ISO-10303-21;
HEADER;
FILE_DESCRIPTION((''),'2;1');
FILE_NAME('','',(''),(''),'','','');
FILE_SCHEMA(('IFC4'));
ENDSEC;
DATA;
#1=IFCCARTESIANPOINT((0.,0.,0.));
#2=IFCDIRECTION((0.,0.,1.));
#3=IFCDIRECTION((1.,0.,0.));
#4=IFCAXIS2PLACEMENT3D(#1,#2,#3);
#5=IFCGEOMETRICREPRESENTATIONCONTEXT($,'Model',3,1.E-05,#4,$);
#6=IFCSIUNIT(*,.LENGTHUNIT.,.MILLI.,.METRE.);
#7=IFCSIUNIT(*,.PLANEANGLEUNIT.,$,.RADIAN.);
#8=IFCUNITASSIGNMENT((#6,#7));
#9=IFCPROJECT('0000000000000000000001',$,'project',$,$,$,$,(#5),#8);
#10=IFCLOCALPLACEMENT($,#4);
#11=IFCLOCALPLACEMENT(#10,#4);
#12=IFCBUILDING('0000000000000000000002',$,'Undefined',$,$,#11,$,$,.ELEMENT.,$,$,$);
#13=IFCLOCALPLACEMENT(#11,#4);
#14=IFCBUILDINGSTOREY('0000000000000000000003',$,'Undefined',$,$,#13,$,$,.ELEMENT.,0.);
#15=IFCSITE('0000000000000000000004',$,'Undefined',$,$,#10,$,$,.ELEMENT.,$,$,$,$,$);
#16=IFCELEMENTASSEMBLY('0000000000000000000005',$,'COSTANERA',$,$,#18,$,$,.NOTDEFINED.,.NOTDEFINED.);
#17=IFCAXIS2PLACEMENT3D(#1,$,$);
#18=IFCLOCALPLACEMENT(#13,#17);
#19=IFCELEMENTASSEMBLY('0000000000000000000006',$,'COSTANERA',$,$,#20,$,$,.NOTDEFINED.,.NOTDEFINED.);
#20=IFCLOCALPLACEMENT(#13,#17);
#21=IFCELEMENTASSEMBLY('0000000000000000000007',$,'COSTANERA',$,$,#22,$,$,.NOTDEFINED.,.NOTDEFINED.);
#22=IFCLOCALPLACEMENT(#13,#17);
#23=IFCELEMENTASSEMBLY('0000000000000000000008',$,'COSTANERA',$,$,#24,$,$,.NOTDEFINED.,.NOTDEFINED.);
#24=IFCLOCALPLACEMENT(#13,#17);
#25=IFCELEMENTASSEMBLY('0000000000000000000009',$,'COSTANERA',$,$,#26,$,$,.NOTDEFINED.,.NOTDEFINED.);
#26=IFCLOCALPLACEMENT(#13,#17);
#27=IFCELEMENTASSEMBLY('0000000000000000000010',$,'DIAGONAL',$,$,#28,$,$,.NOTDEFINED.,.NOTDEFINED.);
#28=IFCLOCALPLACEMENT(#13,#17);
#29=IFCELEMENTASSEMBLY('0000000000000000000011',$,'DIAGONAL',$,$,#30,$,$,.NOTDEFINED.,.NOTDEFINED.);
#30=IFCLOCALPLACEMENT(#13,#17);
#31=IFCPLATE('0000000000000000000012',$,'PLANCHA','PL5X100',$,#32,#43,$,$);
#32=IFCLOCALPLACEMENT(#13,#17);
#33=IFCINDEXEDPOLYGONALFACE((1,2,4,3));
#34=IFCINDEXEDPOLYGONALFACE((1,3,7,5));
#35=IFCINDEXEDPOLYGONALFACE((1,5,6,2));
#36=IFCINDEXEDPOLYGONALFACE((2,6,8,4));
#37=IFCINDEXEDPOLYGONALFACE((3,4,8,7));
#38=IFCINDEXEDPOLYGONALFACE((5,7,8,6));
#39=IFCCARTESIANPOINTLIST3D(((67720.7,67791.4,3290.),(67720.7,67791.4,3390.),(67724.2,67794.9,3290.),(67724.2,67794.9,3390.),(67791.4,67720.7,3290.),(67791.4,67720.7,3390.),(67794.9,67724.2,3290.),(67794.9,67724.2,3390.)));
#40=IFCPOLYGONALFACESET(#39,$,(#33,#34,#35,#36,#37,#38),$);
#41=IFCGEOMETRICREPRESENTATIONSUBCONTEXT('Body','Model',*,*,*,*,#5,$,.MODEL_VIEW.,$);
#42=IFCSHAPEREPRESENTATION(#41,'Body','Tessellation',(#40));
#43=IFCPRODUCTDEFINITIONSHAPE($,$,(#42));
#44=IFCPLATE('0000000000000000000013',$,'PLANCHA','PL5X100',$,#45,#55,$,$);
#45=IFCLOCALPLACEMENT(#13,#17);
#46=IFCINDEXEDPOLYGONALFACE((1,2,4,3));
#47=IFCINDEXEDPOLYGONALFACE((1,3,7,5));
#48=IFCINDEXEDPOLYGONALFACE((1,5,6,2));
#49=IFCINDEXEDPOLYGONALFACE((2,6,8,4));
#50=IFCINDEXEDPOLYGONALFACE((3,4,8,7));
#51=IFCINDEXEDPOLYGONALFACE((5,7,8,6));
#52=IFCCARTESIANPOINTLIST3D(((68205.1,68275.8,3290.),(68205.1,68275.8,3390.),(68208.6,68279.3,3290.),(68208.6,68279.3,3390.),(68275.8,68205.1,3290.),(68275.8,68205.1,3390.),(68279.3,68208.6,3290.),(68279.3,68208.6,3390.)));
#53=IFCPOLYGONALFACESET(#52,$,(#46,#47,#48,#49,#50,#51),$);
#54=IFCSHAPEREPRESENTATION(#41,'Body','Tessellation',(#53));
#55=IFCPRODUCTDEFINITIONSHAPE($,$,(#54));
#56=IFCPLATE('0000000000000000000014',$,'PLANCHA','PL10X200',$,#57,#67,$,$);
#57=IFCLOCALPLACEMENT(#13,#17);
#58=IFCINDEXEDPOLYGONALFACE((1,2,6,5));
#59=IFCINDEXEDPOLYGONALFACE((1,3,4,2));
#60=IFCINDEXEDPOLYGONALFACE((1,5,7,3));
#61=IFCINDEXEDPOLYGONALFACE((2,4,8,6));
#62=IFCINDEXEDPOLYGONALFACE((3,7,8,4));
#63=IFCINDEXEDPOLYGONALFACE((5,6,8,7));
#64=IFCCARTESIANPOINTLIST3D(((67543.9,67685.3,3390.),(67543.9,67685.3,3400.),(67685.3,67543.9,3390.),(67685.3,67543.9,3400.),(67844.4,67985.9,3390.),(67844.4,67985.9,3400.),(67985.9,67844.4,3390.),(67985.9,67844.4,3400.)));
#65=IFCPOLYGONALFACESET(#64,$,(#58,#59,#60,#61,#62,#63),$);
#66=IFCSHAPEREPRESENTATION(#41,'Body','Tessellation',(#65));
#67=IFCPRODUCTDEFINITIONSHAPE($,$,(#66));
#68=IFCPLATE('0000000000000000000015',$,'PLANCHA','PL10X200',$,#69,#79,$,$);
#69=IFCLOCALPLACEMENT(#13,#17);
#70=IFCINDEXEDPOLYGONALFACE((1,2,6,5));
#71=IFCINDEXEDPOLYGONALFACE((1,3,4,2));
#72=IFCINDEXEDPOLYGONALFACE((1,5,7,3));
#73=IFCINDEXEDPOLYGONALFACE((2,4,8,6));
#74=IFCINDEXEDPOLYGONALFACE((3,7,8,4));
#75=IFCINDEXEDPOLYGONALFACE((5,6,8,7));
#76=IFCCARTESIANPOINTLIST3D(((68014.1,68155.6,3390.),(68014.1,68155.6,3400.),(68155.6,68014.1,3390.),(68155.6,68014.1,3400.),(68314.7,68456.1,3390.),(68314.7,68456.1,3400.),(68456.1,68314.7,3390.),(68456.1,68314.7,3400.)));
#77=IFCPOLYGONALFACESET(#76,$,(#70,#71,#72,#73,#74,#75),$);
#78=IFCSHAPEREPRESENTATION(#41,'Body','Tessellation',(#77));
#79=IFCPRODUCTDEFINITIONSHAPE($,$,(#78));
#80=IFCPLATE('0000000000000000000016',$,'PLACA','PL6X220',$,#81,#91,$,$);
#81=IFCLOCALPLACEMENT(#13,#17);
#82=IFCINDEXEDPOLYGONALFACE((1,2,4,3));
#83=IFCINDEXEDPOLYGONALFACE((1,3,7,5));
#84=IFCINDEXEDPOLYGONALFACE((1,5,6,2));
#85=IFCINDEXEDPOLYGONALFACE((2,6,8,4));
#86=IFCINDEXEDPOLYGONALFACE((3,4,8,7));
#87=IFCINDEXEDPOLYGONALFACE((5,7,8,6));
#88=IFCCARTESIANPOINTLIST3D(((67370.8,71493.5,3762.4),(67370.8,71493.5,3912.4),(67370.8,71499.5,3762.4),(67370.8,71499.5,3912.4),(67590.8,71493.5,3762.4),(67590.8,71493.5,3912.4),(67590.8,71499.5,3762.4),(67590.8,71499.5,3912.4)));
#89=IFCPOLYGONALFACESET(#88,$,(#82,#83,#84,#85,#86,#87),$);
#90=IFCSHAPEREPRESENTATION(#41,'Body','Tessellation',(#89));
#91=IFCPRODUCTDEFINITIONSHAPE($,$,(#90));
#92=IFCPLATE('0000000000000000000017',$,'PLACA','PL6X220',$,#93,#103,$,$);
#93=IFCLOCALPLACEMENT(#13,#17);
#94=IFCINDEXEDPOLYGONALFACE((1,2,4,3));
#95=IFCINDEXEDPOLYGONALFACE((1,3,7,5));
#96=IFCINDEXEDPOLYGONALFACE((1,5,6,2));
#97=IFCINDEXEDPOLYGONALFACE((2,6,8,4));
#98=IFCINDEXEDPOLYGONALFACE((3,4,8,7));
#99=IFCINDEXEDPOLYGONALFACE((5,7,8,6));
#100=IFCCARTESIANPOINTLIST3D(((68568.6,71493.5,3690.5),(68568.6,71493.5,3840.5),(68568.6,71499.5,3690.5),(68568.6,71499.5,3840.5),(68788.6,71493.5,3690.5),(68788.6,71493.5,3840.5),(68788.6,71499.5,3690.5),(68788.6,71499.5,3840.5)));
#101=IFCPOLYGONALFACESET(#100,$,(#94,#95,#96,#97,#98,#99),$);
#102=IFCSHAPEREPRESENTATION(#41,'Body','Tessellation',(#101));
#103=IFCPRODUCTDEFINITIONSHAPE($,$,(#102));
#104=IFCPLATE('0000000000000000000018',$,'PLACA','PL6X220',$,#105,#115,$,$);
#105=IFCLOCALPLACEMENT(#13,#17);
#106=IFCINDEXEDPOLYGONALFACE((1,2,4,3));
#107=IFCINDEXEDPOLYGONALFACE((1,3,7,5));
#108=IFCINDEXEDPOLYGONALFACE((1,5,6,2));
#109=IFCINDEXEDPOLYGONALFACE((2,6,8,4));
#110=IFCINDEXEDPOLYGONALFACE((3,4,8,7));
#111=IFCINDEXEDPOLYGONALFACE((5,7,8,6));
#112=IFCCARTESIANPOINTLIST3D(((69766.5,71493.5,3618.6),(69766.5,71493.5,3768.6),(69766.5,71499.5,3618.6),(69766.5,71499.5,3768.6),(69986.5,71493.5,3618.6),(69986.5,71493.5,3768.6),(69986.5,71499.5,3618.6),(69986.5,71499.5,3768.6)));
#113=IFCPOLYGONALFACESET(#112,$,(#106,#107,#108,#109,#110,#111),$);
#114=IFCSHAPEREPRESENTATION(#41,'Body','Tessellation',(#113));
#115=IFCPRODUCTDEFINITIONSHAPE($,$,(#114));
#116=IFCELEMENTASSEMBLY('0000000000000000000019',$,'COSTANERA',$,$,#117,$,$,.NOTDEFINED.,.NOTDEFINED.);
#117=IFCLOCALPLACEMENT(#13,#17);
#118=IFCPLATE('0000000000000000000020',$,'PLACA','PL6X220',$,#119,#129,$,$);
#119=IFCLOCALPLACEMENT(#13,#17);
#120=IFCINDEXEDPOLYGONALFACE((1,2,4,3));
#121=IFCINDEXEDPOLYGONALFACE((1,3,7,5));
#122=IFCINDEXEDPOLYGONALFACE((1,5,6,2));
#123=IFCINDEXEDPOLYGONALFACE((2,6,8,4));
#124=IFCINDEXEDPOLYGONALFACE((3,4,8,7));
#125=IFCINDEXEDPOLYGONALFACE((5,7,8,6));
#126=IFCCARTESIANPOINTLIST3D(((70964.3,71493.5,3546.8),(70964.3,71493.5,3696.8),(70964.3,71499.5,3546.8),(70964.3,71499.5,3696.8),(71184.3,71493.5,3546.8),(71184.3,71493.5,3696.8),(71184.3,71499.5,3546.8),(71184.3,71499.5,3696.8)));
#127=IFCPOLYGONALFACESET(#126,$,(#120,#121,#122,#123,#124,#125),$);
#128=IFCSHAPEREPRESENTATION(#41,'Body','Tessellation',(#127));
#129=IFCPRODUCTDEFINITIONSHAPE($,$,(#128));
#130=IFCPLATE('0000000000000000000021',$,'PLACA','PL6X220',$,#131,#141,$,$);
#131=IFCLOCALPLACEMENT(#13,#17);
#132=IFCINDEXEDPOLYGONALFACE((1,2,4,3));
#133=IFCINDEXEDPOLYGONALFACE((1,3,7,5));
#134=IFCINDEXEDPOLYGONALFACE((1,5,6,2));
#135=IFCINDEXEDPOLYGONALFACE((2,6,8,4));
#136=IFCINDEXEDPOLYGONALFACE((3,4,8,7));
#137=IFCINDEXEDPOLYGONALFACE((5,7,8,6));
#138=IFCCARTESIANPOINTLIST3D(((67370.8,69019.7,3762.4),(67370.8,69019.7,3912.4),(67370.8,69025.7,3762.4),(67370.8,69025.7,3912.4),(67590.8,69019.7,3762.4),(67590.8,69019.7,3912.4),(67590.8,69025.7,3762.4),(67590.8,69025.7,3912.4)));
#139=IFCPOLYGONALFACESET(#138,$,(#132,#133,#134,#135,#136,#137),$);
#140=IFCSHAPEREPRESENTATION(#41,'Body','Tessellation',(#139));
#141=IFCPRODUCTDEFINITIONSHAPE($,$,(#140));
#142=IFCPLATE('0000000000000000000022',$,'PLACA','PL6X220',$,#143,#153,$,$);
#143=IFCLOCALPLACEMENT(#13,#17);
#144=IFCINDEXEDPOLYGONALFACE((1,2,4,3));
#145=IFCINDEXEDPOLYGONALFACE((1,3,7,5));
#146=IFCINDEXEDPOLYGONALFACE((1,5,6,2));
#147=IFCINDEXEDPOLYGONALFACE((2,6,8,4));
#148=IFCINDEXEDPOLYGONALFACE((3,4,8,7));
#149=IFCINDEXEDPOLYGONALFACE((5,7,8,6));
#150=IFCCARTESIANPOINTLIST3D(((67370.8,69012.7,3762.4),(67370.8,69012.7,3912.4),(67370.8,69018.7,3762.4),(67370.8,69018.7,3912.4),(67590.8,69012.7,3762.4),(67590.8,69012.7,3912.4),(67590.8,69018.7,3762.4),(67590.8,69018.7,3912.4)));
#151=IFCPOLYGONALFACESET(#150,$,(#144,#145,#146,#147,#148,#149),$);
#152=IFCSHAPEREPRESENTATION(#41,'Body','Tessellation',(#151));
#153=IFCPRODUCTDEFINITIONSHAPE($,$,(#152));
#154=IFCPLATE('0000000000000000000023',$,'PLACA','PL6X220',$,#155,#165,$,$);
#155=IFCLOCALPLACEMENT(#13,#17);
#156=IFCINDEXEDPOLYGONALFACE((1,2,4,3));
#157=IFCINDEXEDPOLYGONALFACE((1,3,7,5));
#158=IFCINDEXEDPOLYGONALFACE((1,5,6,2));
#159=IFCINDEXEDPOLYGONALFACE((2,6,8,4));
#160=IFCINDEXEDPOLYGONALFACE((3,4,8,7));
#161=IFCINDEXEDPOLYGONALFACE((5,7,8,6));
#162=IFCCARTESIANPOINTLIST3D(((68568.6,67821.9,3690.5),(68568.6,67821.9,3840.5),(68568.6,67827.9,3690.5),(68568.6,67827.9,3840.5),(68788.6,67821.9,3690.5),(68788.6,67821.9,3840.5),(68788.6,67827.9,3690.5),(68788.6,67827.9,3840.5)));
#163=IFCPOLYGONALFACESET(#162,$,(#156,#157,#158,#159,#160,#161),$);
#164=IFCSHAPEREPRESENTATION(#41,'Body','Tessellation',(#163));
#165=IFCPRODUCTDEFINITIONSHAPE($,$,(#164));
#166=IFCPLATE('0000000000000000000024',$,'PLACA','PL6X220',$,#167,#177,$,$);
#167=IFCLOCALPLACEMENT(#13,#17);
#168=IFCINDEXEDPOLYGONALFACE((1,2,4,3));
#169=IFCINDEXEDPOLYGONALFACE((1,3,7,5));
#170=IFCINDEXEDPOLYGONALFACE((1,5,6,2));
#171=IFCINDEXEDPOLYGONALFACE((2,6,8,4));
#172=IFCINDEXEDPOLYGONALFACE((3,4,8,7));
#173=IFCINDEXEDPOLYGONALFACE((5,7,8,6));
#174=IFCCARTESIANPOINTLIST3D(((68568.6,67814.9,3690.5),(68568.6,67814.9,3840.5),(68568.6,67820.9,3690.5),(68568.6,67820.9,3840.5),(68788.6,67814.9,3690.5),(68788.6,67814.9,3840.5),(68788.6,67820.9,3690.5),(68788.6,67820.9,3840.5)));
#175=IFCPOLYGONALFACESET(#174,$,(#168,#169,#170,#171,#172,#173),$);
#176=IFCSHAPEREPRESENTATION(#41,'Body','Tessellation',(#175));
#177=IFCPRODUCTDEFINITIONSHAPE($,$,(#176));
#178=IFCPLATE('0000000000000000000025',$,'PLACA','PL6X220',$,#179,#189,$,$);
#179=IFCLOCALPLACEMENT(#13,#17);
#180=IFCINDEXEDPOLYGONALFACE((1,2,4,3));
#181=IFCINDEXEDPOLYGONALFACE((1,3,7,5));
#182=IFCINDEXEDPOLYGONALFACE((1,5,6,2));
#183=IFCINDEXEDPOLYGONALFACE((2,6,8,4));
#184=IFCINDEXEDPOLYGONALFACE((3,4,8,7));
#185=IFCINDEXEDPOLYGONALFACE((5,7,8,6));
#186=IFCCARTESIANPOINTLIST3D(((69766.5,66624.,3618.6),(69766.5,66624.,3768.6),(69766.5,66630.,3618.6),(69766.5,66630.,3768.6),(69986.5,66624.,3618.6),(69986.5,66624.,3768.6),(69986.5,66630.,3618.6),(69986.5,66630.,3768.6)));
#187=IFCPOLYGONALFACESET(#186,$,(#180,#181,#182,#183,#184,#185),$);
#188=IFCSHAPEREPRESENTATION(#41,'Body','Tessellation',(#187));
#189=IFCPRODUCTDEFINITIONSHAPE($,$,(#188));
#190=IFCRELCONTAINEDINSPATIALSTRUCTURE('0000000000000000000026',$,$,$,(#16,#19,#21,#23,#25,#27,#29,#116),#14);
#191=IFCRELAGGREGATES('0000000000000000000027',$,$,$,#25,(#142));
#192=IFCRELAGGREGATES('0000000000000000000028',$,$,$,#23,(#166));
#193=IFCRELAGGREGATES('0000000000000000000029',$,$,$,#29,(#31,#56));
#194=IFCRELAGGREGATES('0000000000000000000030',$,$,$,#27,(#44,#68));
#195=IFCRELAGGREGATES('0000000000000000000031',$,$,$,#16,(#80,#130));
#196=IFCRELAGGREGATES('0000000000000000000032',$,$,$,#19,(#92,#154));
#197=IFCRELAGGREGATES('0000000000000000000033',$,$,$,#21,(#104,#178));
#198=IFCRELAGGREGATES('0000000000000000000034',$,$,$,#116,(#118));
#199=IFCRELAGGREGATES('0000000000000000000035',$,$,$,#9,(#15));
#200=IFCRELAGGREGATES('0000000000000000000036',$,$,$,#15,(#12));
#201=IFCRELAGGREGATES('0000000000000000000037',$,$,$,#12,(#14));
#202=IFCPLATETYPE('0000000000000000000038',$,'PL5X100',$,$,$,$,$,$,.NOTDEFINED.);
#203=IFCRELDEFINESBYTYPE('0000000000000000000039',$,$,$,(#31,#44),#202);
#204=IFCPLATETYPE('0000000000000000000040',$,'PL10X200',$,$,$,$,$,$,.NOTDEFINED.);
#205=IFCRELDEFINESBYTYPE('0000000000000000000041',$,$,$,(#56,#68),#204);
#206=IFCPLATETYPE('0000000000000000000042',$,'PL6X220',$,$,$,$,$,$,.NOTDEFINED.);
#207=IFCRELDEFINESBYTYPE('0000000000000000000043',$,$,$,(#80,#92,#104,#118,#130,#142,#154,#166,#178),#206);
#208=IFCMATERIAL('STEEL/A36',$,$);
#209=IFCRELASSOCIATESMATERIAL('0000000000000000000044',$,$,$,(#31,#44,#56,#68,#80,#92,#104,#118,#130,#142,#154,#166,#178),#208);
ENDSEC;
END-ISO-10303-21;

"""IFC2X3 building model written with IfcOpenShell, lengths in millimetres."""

from ifc_helpers import new_model, si_unit, frame, origin_with_axes, place, context, subcontext, project, spatial, polyline, outline, extrude, material, type_object, element, aggregate, save


model = new_model("IFC2X3")

# Units and contexts
model_context = context("Model", 3, precision=1e-05, world=origin_with_axes())
body_context = subcontext(model_context, "Body", "Model", "MODEL_VIEW")
ifc_project = project(units=[si_unit("LENGTHUNIT", "METRE", prefix="MILLI"), si_unit("PLANEANGLEUNIT", "RADIAN")], contexts=[model_context])

# Site, building, storey
site_placement = place(None, origin_with_axes())
site = spatial("IfcSite", under=ifc_project, at=site_placement, Name="Undefined", CompositionType="ELEMENT")
building_placement = place(site_placement, origin_with_axes())
building = spatial("IfcBuilding", under=site, at=building_placement, Name="Undefined", CompositionType="ELEMENT")
storey_placement = place(building_placement, origin_with_axes())
storey = spatial("IfcBuildingStorey", under=building, at=storey_placement, Name="Undefined", CompositionType="ELEMENT", Elevation=0.0)

# Element assemblies
assembly_1_placement = place(storey_placement, origin_with_axes())
assembly_1 = element("IfcElementAssembly", 1, at=assembly_1_placement, inside=storey, Name="COSTANERA", AssemblyPlace="NOTDEFINED", PredefinedType="NOTDEFINED")
ifc_material_1 = material(Name="STEEL/A36")
assembly_2_placement = place(storey_placement, origin_with_axes())
assembly_2 = element("IfcElementAssembly", 2, at=assembly_2_placement, inside=storey, Name="COSTANERA", AssemblyPlace="NOTDEFINED", PredefinedType="NOTDEFINED")
assembly_3_placement = place(storey_placement, origin_with_axes())
assembly_3 = element("IfcElementAssembly", 3, at=assembly_3_placement, inside=storey, Name="COSTANERA", AssemblyPlace="NOTDEFINED", PredefinedType="NOTDEFINED")
assembly_4_placement = place(storey_placement, origin_with_axes())
assembly_4 = element("IfcElementAssembly", 4, at=assembly_4_placement, inside=storey, Name="COSTANERA", AssemblyPlace="NOTDEFINED", PredefinedType="NOTDEFINED")
assembly_5_placement = place(storey_placement, origin_with_axes())
assembly_5 = element("IfcElementAssembly", 5, at=assembly_5_placement, inside=storey, Name="COSTANERA", AssemblyPlace="NOTDEFINED", PredefinedType="NOTDEFINED")
assembly_6_placement = place(storey_placement, origin_with_axes())
assembly_6 = element("IfcElementAssembly", 6, at=assembly_6_placement, inside=storey, Name="DIAGONAL", AssemblyPlace="NOTDEFINED", PredefinedType="NOTDEFINED")

# Element assembly, plate
assembly_7_placement = place(storey_placement, origin_with_axes())
assembly_7 = element("IfcElementAssembly", 7, at=assembly_7_placement, inside=storey, Name="DIAGONAL", AssemblyPlace="NOTDEFINED", PredefinedType="NOTDEFINED")
plate_type_1 = type_object("IfcPlateType", Name="PL5X100", PredefinedType="NOTDEFINED")
plate_1_placement = place(assembly_7_placement, frame((67757.8, 67757.8, 3390.0), z_axis=(-0.707107, -0.707107, 0.0), x_axis=(0.0, 0.0, -1.0)))
plate_1 = element("IfcPlate", 8, at=plate_1_placement, type_object=plate_type_1, material=ifc_material_1, Name="PLANCHA", Description="PL5X100", context=body_context, shape_type="SweptSolid", body=[
    extrude(outline(polyline([(0.0, -50.0), (0.0, 50.0), (100.0, 50.0), (100.0, -50.0), (0.0, -50.0)])), frame((0.0, 0.0, -2.5), z_axis=(0.0, 0.0, 1.0), x_axis=(1.0, 0.0, 0.0)), (0.0, 0.0, 1.0), 5.0),
])

# Plates
plate_2_placement = place(assembly_6_placement, frame((68242.2, 68242.2, 3390.0), z_axis=(0.707107, 0.707107, 0.0), x_axis=(0.0, 0.0, -1.0)))
plate_2 = element("IfcPlate", 9, at=plate_2_placement, type_object=plate_type_1, material=ifc_material_1, Name="PLANCHA", Description="PL5X100", context=body_context, shape_type="SweptSolid", body=[
    extrude(outline(polyline([(0.0, -50.0), (0.0, 50.0), (100.0, 50.0), (100.0, -50.0), (0.0, -50.0)])), frame((0.0, 0.0, -2.5), z_axis=(0.0, 0.0, 1.0), x_axis=(1.0, 0.0, 0.0)), (0.0, 0.0, 1.0), 5.0),
])
plate_type_2 = type_object("IfcPlateType", Name="PL10X200", PredefinedType="NOTDEFINED")
plate_3_placement = place(assembly_7_placement, frame((67915.2, 67915.1, 3395.0), z_axis=(0.0, 0.0, 1.0), x_axis=(-0.707107, -0.707107, 0.0)))
plate_3 = element("IfcPlate", 10, at=plate_3_placement, type_object=plate_type_2, material=ifc_material_1, Name="PLANCHA", Description="PL10X200", context=body_context, shape_type="SweptSolid", body=[
    extrude(outline(polyline([(0.0, -100.0), (0.0, 100.0), (425.0, 100.0), (425.0, -100.0), (0.0, -100.0)])), frame((0.0, 0.0, -5.0), z_axis=(0.0, 0.0, 1.0), x_axis=(1.0, 0.0, 0.0)), (0.0, 0.0, 1.0), 10.0),
])
plate_4_placement = place(assembly_6_placement, frame((68084.9, 68084.9, 3395.0), z_axis=(0.0, 0.0, 1.0), x_axis=(0.707107, 0.707107, 0.0)))
plate_4 = element("IfcPlate", 11, at=plate_4_placement, type_object=plate_type_2, material=ifc_material_1, Name="PLANCHA", Description="PL10X200", context=body_context, shape_type="SweptSolid", body=[
    extrude(outline(polyline([(0.0, -100.0), (0.0, 100.0), (425.0, 100.0), (425.0, -100.0), (0.0, -100.0)])), frame((0.0, 0.0, -5.0), z_axis=(0.0, 0.0, 1.0), x_axis=(1.0, 0.0, 0.0)), (0.0, 0.0, 1.0), 10.0),
])
plate_type_3 = type_object("IfcPlateType", Name="PL6X220", PredefinedType="NOTDEFINED")
plate_5_placement = place(assembly_1_placement, frame((67480.8, 71496.5, 3762.4), z_axis=(0.0, 1.0, 0.0), x_axis=(0.0, 0.0, 1.0)))
plate_5 = element("IfcPlate", 12, at=plate_5_placement, type_object=plate_type_3, material=ifc_material_1, Name="PLACA", Description="PL6X220", context=body_context, shape_type="SweptSolid", body=[
    extrude(outline(polyline([(0.0, -110.0), (0.0, 110.0), (150.0, 110.0), (150.0, -110.0), (0.0, -110.0)])), frame((0.0, 0.0, -3.0), z_axis=(0.0, 0.0, 1.0), x_axis=(1.0, 0.0, 0.0)), (0.0, 0.0, 1.0), 6.0),
])
plate_6_placement = place(assembly_2_placement, frame((68678.6, 71496.5, 3690.5), z_axis=(0.0, 1.0, 0.0), x_axis=(0.0, 0.0, 1.0)))
plate_6 = element("IfcPlate", 13, at=plate_6_placement, type_object=plate_type_3, material=ifc_material_1, Name="PLACA", Description="PL6X220", context=body_context, shape_type="SweptSolid", body=[
    extrude(outline(polyline([(0.0, -110.0), (0.0, 110.0), (150.0, 110.0), (150.0, -110.0), (0.0, -110.0)])), frame((0.0, 0.0, -3.0), z_axis=(0.0, 0.0, 1.0), x_axis=(1.0, 0.0, 0.0)), (0.0, 0.0, 1.0), 6.0),
])
plate_7_placement = place(assembly_3_placement, frame((69876.5, 71496.5, 3618.6), z_axis=(0.0, 1.0, 0.0), x_axis=(0.0, 0.0, 1.0)))
plate_7 = element("IfcPlate", 14, at=plate_7_placement, type_object=plate_type_3, material=ifc_material_1, Name="PLACA", Description="PL6X220", context=body_context, shape_type="SweptSolid", body=[
    extrude(outline(polyline([(0.0, -110.0), (0.0, 110.0), (150.0, 110.0), (150.0, -110.0), (0.0, -110.0)])), frame((0.0, 0.0, -3.0), z_axis=(0.0, 0.0, 1.0), x_axis=(1.0, 0.0, 0.0)), (0.0, 0.0, 1.0), 6.0),
])

# Element assembly, plate
assembly_8_placement = place(storey_placement, origin_with_axes())
assembly_8 = element("IfcElementAssembly", 15, at=assembly_8_placement, inside=storey, Name="COSTANERA", AssemblyPlace="NOTDEFINED", PredefinedType="NOTDEFINED")
plate_8_placement = place(assembly_8_placement, frame((71074.3, 71496.5, 3546.8), z_axis=(0.0, 1.0, 0.0), x_axis=(0.0, 0.0, 1.0)))
plate_8 = element("IfcPlate", 16, at=plate_8_placement, type_object=plate_type_3, material=ifc_material_1, Name="PLACA", Description="PL6X220", context=body_context, shape_type="SweptSolid", body=[
    extrude(outline(polyline([(0.0, -110.0), (0.0, 110.0), (150.0, 110.0), (150.0, -110.0), (0.0, -110.0)])), frame((0.0, 0.0, -3.0), z_axis=(0.0, 0.0, 1.0), x_axis=(1.0, 0.0, 0.0)), (0.0, 0.0, 1.0), 6.0),
])

# Plates
plate_9_placement = place(assembly_1_placement, frame((67480.8, 69022.7, 3762.4), z_axis=(0.0, 1.0, 0.0), x_axis=(0.0, 0.0, 1.0)))
plate_9 = element("IfcPlate", 17, at=plate_9_placement, type_object=plate_type_3, material=ifc_material_1, Name="PLACA", Description="PL6X220", context=body_context, shape_type="SweptSolid", body=[
    extrude(outline(polyline([(0.0, -110.0), (0.0, 110.0), (150.0, 110.0), (150.0, -110.0), (0.0, -110.0)])), frame((0.0, 0.0, -3.0), z_axis=(0.0, 0.0, 1.0), x_axis=(1.0, 0.0, 0.0)), (0.0, 0.0, 1.0), 6.0),
])
plate_10_placement = place(assembly_5_placement, frame((67480.8, 69015.7, 3762.4), z_axis=(0.0, 1.0, 0.0), x_axis=(0.0, 0.0, 1.0)))
plate_10 = element("IfcPlate", 18, at=plate_10_placement, type_object=plate_type_3, material=ifc_material_1, Name="PLACA", Description="PL6X220", context=body_context, shape_type="SweptSolid", body=[
    extrude(outline(polyline([(0.0, -110.0), (0.0, 110.0), (150.0, 110.0), (150.0, -110.0), (0.0, -110.0)])), frame((0.0, 0.0, -3.0), z_axis=(0.0, 0.0, 1.0), x_axis=(1.0, 0.0, 0.0)), (0.0, 0.0, 1.0), 6.0),
])
aggregate(assembly_5, [plate_10])
plate_11_placement = place(assembly_2_placement, frame((68678.6, 67824.9, 3690.5), z_axis=(0.0, 1.0, 0.0), x_axis=(0.0, 0.0, 1.0)))
plate_11 = element("IfcPlate", 19, at=plate_11_placement, type_object=plate_type_3, material=ifc_material_1, Name="PLACA", Description="PL6X220", context=body_context, shape_type="SweptSolid", body=[
    extrude(outline(polyline([(0.0, -110.0), (0.0, 110.0), (150.0, 110.0), (150.0, -110.0), (0.0, -110.0)])), frame((0.0, 0.0, -3.0), z_axis=(0.0, 0.0, 1.0), x_axis=(1.0, 0.0, 0.0)), (0.0, 0.0, 1.0), 6.0),
])
plate_12_placement = place(assembly_4_placement, frame((68678.6, 67817.9, 3690.5), z_axis=(0.0, 1.0, 0.0), x_axis=(0.0, 0.0, 1.0)))
plate_12 = element("IfcPlate", 20, at=plate_12_placement, type_object=plate_type_3, material=ifc_material_1, Name="PLACA", Description="PL6X220", context=body_context, shape_type="SweptSolid", body=[
    extrude(outline(polyline([(0.0, -110.0), (0.0, 110.0), (150.0, 110.0), (150.0, -110.0), (0.0, -110.0)])), frame((0.0, 0.0, -3.0), z_axis=(0.0, 0.0, 1.0), x_axis=(1.0, 0.0, 0.0)), (0.0, 0.0, 1.0), 6.0),
])
aggregate(assembly_4, [plate_12])
plate_13_placement = place(assembly_3_placement, frame((69876.5, 66627.0, 3618.6), z_axis=(0.0, 1.0, 0.0), x_axis=(0.0, 0.0, 1.0)))
plate_13 = element("IfcPlate", 21, at=plate_13_placement, type_object=plate_type_3, material=ifc_material_1, Name="PLACA", Description="PL6X220", context=body_context, shape_type="SweptSolid", body=[
    extrude(outline(polyline([(0.0, -110.0), (0.0, 110.0), (150.0, 110.0), (150.0, -110.0), (0.0, -110.0)])), frame((0.0, 0.0, -3.0), z_axis=(0.0, 0.0, 1.0), x_axis=(1.0, 0.0, 0.0)), (0.0, 0.0, 1.0), 6.0),
])

aggregate(assembly_7, [plate_1, plate_3])
aggregate(assembly_6, [plate_2, plate_4])
aggregate(assembly_1, [plate_5, plate_9])
aggregate(assembly_2, [plate_6, plate_11])
aggregate(assembly_3, [plate_7, plate_13])
aggregate(assembly_8, [plate_8])

save(model, "model.ifc")
